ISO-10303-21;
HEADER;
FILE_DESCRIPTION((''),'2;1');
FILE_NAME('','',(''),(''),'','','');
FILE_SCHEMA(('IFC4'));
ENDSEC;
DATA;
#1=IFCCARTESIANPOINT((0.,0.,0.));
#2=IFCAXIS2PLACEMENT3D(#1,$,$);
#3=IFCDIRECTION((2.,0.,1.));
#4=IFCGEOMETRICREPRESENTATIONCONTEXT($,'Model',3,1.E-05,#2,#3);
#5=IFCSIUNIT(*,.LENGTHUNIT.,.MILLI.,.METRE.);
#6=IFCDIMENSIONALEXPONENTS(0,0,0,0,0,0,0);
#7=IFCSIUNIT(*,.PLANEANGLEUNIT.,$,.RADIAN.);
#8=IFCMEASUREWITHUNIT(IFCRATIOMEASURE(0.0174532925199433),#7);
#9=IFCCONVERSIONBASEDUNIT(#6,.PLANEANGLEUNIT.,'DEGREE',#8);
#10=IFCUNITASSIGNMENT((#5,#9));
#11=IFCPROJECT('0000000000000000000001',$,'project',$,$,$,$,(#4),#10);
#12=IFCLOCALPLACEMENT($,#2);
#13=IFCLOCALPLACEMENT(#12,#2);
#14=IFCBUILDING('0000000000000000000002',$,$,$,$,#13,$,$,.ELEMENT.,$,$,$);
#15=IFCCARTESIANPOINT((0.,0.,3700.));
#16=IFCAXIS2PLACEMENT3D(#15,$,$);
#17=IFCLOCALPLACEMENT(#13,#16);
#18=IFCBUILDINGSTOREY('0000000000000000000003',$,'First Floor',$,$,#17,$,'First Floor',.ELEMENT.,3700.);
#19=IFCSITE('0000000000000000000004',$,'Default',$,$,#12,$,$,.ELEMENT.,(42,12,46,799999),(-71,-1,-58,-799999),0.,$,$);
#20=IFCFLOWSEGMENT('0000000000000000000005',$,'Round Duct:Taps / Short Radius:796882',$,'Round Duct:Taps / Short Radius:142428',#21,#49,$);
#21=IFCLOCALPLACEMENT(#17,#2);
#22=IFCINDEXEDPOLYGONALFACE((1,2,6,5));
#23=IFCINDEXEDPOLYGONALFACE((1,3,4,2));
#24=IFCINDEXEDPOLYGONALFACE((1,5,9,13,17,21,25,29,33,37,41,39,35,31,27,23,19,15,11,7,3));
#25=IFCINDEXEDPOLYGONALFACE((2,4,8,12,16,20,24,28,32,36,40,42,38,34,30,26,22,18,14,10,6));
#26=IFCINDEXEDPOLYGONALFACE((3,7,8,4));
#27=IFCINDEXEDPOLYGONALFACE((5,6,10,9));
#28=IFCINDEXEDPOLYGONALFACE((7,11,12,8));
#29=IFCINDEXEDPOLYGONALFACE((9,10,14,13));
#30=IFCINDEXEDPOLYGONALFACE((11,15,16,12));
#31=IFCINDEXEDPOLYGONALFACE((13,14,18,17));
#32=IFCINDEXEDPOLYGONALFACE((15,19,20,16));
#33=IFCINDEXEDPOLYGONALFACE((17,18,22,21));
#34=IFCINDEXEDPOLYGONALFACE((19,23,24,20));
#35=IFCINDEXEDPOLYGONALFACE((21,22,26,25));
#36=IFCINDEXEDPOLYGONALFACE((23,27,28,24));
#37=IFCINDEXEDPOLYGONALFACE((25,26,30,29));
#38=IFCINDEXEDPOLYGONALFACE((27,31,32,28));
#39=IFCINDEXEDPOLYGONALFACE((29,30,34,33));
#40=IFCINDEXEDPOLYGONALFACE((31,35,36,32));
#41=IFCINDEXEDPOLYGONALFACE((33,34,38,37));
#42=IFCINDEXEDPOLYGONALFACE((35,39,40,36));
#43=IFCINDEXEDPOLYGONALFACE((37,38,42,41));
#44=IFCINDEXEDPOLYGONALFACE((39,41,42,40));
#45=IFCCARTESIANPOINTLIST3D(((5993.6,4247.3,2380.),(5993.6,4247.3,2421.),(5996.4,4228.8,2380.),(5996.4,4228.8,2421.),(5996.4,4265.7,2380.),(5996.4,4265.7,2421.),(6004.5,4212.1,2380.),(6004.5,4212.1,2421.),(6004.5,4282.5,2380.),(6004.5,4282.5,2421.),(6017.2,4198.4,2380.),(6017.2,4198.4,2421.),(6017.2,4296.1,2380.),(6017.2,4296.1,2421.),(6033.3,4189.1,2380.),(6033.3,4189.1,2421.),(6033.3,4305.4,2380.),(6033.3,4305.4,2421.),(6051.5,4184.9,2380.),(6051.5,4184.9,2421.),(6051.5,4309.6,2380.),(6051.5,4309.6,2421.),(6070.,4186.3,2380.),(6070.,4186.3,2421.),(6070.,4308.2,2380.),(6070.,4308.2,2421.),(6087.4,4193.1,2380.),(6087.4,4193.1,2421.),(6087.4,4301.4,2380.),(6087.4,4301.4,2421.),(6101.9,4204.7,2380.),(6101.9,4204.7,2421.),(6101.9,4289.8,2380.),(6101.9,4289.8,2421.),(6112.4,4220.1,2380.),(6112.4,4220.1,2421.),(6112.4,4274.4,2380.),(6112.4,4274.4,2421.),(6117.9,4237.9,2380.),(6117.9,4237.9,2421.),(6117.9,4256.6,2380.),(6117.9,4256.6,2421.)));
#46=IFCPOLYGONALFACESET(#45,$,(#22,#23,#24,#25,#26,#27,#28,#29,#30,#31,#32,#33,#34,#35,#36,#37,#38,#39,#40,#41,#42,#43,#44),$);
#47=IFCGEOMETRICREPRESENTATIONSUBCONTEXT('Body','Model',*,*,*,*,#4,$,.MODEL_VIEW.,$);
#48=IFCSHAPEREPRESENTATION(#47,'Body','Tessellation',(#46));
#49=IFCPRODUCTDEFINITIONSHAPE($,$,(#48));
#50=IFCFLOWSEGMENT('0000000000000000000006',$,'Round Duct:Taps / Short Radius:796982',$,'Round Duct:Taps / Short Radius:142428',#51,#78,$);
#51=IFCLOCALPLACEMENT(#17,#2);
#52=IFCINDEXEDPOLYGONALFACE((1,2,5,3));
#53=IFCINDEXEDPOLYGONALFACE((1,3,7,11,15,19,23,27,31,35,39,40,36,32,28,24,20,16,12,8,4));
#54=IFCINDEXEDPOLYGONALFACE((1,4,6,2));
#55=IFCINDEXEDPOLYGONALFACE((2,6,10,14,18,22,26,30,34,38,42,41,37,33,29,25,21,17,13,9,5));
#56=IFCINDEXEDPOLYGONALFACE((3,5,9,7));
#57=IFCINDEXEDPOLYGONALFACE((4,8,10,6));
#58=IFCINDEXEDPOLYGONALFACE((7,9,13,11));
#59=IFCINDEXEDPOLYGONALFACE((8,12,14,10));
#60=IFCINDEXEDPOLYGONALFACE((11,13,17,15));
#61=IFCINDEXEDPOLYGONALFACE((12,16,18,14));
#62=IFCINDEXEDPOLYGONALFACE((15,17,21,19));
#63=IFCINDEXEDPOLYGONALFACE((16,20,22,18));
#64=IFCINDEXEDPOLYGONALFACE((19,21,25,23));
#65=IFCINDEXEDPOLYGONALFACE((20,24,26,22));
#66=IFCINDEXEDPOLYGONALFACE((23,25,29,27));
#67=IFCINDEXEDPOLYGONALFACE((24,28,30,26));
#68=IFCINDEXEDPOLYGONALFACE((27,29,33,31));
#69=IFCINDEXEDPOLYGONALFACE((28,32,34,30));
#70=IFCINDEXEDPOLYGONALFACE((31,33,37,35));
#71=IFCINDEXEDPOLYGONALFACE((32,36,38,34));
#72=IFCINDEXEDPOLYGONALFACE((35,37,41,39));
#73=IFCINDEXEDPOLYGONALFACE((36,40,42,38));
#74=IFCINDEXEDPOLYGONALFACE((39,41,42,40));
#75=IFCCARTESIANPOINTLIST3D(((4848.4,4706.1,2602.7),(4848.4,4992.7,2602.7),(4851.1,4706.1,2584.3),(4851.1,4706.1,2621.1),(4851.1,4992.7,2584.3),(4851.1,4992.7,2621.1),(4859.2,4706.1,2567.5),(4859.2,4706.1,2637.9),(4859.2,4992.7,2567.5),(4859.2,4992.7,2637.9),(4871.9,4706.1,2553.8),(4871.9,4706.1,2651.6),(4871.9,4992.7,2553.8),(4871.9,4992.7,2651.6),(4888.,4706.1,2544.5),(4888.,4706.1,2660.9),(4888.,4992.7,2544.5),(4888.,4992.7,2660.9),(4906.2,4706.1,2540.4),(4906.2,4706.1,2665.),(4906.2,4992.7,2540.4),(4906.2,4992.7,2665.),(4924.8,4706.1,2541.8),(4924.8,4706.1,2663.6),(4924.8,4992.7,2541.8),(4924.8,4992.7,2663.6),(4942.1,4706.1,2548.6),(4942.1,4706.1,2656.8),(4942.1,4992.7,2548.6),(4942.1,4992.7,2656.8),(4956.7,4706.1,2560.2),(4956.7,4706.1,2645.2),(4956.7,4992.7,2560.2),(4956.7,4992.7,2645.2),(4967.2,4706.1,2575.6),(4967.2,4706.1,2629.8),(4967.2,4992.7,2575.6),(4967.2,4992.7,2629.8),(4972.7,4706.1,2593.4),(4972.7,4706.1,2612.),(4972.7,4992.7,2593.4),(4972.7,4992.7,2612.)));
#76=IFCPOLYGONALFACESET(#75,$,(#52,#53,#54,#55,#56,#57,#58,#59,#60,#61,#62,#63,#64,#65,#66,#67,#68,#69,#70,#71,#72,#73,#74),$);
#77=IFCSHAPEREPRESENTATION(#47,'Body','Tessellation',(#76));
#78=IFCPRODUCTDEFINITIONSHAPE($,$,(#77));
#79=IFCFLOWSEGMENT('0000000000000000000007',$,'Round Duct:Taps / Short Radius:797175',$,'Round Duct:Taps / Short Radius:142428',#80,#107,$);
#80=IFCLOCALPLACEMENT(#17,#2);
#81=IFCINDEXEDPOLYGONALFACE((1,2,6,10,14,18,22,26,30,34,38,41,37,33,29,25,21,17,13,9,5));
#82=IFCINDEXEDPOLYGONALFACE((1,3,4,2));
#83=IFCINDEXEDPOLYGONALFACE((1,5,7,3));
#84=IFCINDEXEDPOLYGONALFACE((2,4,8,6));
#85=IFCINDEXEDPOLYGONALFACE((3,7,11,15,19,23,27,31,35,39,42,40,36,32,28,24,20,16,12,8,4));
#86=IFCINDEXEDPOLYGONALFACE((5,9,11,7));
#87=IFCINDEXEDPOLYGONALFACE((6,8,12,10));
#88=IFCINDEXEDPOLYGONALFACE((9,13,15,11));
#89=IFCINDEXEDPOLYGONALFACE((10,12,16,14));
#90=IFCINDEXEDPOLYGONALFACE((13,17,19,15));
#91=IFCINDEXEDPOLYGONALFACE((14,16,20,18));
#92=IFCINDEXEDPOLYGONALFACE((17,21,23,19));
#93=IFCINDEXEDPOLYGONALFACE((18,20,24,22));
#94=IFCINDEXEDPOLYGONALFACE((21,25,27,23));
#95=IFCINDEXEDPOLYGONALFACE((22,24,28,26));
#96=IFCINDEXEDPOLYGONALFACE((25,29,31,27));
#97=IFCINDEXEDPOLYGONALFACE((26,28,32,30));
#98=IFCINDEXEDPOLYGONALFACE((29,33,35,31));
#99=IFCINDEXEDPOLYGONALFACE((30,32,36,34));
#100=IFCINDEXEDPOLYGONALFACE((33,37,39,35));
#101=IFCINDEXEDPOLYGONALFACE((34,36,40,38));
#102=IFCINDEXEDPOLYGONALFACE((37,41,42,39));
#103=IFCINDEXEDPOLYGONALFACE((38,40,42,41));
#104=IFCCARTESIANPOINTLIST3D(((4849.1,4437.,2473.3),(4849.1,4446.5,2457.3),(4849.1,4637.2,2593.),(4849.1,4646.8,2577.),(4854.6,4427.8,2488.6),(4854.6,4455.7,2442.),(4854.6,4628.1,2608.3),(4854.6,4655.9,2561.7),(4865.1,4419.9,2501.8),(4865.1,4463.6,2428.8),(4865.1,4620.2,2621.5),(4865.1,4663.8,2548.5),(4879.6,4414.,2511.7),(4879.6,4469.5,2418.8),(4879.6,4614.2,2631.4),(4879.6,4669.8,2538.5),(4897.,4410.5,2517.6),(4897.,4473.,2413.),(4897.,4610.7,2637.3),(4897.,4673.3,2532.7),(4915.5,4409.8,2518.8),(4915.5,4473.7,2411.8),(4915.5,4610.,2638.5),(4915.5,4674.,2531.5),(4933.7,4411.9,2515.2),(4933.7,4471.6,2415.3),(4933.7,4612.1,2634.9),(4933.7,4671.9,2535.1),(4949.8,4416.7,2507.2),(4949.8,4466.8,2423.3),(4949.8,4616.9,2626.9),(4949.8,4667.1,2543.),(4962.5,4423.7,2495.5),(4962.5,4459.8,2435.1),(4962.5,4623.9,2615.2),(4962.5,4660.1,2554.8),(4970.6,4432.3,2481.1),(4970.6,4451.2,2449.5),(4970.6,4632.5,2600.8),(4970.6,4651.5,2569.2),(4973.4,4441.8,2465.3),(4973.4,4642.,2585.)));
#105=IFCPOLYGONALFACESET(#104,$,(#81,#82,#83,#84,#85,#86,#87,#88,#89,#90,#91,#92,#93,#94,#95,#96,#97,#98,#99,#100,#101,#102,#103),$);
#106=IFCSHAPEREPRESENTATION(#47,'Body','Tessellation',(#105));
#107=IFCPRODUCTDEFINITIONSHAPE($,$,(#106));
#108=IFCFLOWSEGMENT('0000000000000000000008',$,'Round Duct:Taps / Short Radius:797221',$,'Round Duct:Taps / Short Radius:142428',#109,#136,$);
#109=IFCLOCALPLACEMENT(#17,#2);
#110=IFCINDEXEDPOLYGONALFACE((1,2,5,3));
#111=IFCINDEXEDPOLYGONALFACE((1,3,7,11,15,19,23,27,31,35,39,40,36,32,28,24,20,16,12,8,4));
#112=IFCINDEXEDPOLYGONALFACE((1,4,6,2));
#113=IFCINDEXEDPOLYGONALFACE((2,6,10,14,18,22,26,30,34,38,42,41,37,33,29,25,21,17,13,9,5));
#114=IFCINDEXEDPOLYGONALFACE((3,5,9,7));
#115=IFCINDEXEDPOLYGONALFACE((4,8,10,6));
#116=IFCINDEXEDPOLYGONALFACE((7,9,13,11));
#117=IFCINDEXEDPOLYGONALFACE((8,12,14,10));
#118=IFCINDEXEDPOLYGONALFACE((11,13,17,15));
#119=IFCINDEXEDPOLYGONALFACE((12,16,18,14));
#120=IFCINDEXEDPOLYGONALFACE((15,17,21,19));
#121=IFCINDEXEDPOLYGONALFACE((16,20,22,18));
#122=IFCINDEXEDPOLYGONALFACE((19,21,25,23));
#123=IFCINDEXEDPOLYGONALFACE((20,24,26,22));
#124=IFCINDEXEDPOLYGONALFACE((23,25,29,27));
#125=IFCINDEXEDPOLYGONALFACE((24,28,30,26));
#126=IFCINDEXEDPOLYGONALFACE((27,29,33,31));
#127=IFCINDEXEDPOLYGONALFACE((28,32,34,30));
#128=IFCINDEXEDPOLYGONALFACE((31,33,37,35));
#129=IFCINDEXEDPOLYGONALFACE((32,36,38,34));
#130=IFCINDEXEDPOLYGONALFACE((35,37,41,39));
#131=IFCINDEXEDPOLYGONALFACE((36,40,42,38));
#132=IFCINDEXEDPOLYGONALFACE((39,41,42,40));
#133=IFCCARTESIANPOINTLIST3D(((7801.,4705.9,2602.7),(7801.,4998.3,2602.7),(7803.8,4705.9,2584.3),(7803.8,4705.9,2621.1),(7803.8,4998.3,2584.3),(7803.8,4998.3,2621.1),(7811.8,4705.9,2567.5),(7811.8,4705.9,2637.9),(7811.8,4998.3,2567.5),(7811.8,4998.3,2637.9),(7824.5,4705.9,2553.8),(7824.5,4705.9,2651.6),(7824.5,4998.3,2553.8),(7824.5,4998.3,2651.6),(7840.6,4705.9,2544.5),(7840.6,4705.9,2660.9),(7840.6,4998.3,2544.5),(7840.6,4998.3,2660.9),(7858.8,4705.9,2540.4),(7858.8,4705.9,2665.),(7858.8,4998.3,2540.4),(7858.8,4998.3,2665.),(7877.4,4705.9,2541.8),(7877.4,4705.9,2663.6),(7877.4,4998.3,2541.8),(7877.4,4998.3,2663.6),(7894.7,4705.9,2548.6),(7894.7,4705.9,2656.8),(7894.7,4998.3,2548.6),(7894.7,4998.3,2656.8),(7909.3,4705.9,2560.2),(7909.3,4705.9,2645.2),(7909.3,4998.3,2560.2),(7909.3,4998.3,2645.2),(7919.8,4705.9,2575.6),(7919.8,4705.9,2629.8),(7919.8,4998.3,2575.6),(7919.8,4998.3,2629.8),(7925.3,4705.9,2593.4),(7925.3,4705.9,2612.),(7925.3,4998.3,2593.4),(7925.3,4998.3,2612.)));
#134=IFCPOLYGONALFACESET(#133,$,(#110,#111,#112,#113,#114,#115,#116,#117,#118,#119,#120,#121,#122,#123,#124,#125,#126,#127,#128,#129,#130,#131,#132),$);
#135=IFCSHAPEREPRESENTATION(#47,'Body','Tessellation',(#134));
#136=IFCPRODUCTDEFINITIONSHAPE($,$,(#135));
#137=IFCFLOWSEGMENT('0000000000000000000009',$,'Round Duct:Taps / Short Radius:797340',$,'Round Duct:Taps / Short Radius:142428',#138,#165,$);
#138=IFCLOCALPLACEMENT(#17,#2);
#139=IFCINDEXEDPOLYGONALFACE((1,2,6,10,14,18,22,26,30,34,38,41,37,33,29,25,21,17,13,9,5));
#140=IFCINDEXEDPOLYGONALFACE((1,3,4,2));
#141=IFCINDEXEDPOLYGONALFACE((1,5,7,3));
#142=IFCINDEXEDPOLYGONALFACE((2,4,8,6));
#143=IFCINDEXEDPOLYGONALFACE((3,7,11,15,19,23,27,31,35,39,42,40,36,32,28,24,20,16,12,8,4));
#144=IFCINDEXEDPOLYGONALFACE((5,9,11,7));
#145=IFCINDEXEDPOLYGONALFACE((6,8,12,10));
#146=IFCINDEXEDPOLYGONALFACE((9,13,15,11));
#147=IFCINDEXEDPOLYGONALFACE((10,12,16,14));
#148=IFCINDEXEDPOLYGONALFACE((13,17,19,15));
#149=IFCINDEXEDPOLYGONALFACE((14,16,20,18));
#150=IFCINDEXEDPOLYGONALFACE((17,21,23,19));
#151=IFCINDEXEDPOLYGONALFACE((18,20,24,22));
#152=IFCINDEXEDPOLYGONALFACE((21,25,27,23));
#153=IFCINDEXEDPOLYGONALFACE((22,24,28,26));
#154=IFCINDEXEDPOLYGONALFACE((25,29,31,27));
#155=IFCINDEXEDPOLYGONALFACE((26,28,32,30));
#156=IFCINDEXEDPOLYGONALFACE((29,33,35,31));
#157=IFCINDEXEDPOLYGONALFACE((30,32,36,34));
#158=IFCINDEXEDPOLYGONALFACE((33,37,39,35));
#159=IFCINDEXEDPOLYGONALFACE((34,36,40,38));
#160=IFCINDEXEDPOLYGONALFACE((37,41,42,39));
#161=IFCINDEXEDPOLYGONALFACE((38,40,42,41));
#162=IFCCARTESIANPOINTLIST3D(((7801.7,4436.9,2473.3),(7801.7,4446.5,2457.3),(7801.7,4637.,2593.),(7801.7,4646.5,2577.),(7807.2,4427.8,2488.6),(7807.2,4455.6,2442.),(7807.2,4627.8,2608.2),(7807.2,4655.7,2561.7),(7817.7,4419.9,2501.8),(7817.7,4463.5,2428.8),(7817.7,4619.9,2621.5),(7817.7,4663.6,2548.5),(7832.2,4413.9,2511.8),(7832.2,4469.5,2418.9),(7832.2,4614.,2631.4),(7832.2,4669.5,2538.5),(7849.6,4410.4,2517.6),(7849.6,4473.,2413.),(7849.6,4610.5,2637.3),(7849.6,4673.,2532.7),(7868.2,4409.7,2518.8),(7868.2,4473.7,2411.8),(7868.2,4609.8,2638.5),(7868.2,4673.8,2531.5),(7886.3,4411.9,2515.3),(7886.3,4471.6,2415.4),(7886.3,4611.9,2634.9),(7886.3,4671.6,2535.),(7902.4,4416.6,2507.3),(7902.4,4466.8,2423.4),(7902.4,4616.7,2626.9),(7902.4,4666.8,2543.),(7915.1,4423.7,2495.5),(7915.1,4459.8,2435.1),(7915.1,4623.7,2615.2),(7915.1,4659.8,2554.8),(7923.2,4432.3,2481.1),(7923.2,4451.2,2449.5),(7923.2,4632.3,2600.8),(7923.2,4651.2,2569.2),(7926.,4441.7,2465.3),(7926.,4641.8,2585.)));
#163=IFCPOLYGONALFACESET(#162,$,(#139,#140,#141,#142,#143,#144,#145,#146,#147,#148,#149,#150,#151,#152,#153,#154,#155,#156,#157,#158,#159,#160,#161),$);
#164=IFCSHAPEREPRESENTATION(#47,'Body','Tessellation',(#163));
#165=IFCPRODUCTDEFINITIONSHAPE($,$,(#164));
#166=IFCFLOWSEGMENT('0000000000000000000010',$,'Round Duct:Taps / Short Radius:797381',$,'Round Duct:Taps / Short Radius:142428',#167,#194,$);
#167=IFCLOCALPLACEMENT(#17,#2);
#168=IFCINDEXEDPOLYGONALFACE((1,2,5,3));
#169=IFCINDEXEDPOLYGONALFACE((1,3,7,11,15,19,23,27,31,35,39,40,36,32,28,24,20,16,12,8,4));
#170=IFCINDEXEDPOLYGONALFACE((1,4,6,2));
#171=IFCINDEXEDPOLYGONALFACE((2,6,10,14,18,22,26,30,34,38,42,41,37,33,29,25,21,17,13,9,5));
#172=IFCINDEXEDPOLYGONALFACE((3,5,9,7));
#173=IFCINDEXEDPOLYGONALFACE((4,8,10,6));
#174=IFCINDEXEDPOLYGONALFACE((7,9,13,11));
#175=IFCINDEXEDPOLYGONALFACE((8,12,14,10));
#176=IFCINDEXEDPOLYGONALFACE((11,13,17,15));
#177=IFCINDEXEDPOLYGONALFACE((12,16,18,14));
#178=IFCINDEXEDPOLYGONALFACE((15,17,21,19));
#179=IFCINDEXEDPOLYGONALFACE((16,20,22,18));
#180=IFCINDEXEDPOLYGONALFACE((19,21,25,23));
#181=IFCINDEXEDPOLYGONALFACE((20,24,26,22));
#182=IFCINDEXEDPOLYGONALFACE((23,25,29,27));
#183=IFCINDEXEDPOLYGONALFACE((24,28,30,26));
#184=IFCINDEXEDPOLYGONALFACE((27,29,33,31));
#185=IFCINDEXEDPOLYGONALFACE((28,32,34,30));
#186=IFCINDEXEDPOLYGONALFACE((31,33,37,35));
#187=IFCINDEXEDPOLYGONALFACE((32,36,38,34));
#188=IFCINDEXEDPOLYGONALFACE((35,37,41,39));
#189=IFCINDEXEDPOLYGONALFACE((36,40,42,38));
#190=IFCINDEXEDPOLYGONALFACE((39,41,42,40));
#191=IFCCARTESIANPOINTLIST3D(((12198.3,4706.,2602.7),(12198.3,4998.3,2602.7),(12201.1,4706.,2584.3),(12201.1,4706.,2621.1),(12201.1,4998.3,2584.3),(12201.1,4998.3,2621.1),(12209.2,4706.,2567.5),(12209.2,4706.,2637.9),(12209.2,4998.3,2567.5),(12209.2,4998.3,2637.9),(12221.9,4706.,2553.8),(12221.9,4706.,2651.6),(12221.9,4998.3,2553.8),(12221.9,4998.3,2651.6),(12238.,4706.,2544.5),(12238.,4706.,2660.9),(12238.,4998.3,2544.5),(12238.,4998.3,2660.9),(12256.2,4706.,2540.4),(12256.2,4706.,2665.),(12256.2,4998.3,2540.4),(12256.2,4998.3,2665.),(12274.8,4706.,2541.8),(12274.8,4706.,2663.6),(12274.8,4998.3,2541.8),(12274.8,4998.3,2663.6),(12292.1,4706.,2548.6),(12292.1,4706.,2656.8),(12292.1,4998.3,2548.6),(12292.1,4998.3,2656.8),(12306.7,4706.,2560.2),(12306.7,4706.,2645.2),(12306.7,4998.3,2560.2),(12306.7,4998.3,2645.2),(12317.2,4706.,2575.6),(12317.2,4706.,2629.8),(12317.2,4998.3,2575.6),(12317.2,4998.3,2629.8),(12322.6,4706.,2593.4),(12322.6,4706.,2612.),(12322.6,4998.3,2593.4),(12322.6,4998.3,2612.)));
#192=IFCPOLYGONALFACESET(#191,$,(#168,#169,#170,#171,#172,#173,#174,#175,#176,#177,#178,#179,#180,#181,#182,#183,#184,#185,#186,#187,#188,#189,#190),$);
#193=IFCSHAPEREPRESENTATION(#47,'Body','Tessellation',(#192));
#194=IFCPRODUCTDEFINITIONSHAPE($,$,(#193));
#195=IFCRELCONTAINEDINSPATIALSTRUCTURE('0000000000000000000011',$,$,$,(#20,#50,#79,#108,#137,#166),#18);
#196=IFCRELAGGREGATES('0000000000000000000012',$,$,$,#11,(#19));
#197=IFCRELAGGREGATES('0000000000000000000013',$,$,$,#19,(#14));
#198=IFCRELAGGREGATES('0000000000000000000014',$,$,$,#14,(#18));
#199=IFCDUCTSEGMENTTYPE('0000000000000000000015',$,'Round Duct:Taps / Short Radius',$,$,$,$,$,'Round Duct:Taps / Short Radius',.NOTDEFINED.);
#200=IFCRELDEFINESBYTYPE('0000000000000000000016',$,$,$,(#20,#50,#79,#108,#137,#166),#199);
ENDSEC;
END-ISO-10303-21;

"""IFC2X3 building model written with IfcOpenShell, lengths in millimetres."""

from ifc_helpers import new_model, entity, si_unit, converted_unit, direction, frame, frame_2d, origin, place, context, subcontext, project, spatial, circle, extrude, type_object, element, save


model = new_model("IFC2X3")

# Units and contexts
model_context = context("Model", 3, precision=1e-05, world=origin(), true_north=direction((2.0, 0.0, 1.0)))
body_context = subcontext(model_context, "Body", "Model", "MODEL_VIEW")
ifc_project = project(units=[si_unit("LENGTHUNIT", "METRE", prefix="MILLI"), converted_unit("PLANEANGLEUNIT", "DEGREE", entity("IfcRatioMeasure", 0.0174532925199433), si_unit("PLANEANGLEUNIT", "RADIAN"), dimensions=[0, 0, 0, 0, 0, 0, 0])], contexts=[model_context])

# Site, building, storey
site_placement = place(None, origin())
site = spatial("IfcSite", under=ifc_project, at=site_placement, Name="Default", CompositionType="ELEMENT", RefLatitude=(42, 12, 46, 799999), RefLongitude=(-71, -1, -58, -799999), RefElevation=0.0)
building_placement = place(site_placement, origin())
building = spatial("IfcBuilding", under=site, at=building_placement, CompositionType="ELEMENT")
storey_placement = place(building_placement, frame((0.0, 0.0, 3700.0)))
storey = spatial("IfcBuildingStorey", under=building, at=storey_placement, Name="First Floor", LongName="First Floor", CompositionType="ELEMENT", Elevation=3700.0)

# Flow segments
duct_segment_type = type_object("IfcDuctSegmentType", Name="Round Duct:Taps / Short Radius", ElementType="Round Duct:Taps / Short Radius", PredefinedType="NOTDEFINED")
flow_segment_1_placement = place(storey_placement, origin())
element("IfcFlowSegment", 1, at=flow_segment_1_placement, inside=storey, type_object=duct_segment_type, Name="Round Duct:Taps / Short Radius:796882", ObjectType="Round Duct:Taps / Short Radius:142428", context=body_context, shape_type="SweptSolid", body=[
    extrude(circle(Radius=62.5, at=frame_2d((0.0, 0.0), x_axis=(1.0, 0.0))), frame((6056.1, 4247.3, 2380.0), z_axis=(0.0, 0.0, 1.0), x_axis=(-1.0, 0.0, 0.0)), (0.0, 0.0, 1.0), 41.0),
])
flow_segment_2_placement = place(storey_placement, origin())
element("IfcFlowSegment", 2, at=flow_segment_2_placement, inside=storey, type_object=duct_segment_type, Name="Round Duct:Taps / Short Radius:796982", ObjectType="Round Duct:Taps / Short Radius:142428", context=body_context, shape_type="SweptSolid", body=[
    extrude(circle(Radius=62.5, at=frame_2d((0.0, 0.0), x_axis=(1.0, 0.0))), frame((4910.9, 4706.1, 2602.7), z_axis=(0.0, 1.0, 0.0), x_axis=(-1.0, 0.0, 0.0)), (0.0, 0.0, 1.0), 286.6),
])
flow_segment_3_placement = place(storey_placement, origin())
element("IfcFlowSegment", 3, at=flow_segment_3_placement, inside=storey, type_object=duct_segment_type, Name="Round Duct:Taps / Short Radius:797175", ObjectType="Round Duct:Taps / Short Radius:142428", context=body_context, shape_type="SweptSolid", body=[
    extrude(circle(Radius=62.5, at=frame_2d((0.0, 0.0), x_axis=(1.0, 0.0))), frame((4910.9, 4441.8, 2465.3), z_axis=(0.0, 0.858311, 0.51313), x_axis=(1.0, 0.0, 0.0)), (0.0, 0.0, 1.0), 233.3),
])
flow_segment_4_placement = place(storey_placement, origin())
element("IfcFlowSegment", 4, at=flow_segment_4_placement, inside=storey, type_object=duct_segment_type, Name="Round Duct:Taps / Short Radius:797221", ObjectType="Round Duct:Taps / Short Radius:142428", context=body_context, shape_type="SweptSolid", body=[
    extrude(circle(Radius=62.5, at=frame_2d((0.0, 0.0), x_axis=(1.0, 0.0))), frame((7863.5, 4705.9, 2602.7), z_axis=(0.0, 1.0, 0.0), x_axis=(-1.0, 0.0, 0.0)), (0.0, 0.0, 1.0), 292.4),
])
flow_segment_5_placement = place(storey_placement, origin())
element("IfcFlowSegment", 5, at=flow_segment_5_placement, inside=storey, type_object=duct_segment_type, Name="Round Duct:Taps / Short Radius:797340", ObjectType="Round Duct:Taps / Short Radius:142428", context=body_context, shape_type="SweptSolid", body=[
    extrude(circle(Radius=62.5, at=frame_2d((0.0, 0.0), x_axis=(1.0, 0.0))), frame((7863.5, 4441.7, 2465.3), z_axis=(0.0, 0.858188, 0.513336), x_axis=(1.0, 0.0, 0.0)), (0.0, 0.0, 1.0), 233.1),
])
flow_segment_6_placement = place(storey_placement, origin())
element("IfcFlowSegment", 6, at=flow_segment_6_placement, inside=storey, type_object=duct_segment_type, Name="Round Duct:Taps / Short Radius:797381", ObjectType="Round Duct:Taps / Short Radius:142428", context=body_context, shape_type="SweptSolid", body=[
    extrude(circle(Radius=62.5, at=frame_2d((0.0, 0.0), x_axis=(1.0, 0.0))), frame((12260.8, 4706.0, 2602.7), z_axis=(0.0, 1.0, 0.0), x_axis=(-1.0, 0.0, 0.0)), (0.0, 0.0, 1.0), 292.4),
])

save(model, "model.ifc")
